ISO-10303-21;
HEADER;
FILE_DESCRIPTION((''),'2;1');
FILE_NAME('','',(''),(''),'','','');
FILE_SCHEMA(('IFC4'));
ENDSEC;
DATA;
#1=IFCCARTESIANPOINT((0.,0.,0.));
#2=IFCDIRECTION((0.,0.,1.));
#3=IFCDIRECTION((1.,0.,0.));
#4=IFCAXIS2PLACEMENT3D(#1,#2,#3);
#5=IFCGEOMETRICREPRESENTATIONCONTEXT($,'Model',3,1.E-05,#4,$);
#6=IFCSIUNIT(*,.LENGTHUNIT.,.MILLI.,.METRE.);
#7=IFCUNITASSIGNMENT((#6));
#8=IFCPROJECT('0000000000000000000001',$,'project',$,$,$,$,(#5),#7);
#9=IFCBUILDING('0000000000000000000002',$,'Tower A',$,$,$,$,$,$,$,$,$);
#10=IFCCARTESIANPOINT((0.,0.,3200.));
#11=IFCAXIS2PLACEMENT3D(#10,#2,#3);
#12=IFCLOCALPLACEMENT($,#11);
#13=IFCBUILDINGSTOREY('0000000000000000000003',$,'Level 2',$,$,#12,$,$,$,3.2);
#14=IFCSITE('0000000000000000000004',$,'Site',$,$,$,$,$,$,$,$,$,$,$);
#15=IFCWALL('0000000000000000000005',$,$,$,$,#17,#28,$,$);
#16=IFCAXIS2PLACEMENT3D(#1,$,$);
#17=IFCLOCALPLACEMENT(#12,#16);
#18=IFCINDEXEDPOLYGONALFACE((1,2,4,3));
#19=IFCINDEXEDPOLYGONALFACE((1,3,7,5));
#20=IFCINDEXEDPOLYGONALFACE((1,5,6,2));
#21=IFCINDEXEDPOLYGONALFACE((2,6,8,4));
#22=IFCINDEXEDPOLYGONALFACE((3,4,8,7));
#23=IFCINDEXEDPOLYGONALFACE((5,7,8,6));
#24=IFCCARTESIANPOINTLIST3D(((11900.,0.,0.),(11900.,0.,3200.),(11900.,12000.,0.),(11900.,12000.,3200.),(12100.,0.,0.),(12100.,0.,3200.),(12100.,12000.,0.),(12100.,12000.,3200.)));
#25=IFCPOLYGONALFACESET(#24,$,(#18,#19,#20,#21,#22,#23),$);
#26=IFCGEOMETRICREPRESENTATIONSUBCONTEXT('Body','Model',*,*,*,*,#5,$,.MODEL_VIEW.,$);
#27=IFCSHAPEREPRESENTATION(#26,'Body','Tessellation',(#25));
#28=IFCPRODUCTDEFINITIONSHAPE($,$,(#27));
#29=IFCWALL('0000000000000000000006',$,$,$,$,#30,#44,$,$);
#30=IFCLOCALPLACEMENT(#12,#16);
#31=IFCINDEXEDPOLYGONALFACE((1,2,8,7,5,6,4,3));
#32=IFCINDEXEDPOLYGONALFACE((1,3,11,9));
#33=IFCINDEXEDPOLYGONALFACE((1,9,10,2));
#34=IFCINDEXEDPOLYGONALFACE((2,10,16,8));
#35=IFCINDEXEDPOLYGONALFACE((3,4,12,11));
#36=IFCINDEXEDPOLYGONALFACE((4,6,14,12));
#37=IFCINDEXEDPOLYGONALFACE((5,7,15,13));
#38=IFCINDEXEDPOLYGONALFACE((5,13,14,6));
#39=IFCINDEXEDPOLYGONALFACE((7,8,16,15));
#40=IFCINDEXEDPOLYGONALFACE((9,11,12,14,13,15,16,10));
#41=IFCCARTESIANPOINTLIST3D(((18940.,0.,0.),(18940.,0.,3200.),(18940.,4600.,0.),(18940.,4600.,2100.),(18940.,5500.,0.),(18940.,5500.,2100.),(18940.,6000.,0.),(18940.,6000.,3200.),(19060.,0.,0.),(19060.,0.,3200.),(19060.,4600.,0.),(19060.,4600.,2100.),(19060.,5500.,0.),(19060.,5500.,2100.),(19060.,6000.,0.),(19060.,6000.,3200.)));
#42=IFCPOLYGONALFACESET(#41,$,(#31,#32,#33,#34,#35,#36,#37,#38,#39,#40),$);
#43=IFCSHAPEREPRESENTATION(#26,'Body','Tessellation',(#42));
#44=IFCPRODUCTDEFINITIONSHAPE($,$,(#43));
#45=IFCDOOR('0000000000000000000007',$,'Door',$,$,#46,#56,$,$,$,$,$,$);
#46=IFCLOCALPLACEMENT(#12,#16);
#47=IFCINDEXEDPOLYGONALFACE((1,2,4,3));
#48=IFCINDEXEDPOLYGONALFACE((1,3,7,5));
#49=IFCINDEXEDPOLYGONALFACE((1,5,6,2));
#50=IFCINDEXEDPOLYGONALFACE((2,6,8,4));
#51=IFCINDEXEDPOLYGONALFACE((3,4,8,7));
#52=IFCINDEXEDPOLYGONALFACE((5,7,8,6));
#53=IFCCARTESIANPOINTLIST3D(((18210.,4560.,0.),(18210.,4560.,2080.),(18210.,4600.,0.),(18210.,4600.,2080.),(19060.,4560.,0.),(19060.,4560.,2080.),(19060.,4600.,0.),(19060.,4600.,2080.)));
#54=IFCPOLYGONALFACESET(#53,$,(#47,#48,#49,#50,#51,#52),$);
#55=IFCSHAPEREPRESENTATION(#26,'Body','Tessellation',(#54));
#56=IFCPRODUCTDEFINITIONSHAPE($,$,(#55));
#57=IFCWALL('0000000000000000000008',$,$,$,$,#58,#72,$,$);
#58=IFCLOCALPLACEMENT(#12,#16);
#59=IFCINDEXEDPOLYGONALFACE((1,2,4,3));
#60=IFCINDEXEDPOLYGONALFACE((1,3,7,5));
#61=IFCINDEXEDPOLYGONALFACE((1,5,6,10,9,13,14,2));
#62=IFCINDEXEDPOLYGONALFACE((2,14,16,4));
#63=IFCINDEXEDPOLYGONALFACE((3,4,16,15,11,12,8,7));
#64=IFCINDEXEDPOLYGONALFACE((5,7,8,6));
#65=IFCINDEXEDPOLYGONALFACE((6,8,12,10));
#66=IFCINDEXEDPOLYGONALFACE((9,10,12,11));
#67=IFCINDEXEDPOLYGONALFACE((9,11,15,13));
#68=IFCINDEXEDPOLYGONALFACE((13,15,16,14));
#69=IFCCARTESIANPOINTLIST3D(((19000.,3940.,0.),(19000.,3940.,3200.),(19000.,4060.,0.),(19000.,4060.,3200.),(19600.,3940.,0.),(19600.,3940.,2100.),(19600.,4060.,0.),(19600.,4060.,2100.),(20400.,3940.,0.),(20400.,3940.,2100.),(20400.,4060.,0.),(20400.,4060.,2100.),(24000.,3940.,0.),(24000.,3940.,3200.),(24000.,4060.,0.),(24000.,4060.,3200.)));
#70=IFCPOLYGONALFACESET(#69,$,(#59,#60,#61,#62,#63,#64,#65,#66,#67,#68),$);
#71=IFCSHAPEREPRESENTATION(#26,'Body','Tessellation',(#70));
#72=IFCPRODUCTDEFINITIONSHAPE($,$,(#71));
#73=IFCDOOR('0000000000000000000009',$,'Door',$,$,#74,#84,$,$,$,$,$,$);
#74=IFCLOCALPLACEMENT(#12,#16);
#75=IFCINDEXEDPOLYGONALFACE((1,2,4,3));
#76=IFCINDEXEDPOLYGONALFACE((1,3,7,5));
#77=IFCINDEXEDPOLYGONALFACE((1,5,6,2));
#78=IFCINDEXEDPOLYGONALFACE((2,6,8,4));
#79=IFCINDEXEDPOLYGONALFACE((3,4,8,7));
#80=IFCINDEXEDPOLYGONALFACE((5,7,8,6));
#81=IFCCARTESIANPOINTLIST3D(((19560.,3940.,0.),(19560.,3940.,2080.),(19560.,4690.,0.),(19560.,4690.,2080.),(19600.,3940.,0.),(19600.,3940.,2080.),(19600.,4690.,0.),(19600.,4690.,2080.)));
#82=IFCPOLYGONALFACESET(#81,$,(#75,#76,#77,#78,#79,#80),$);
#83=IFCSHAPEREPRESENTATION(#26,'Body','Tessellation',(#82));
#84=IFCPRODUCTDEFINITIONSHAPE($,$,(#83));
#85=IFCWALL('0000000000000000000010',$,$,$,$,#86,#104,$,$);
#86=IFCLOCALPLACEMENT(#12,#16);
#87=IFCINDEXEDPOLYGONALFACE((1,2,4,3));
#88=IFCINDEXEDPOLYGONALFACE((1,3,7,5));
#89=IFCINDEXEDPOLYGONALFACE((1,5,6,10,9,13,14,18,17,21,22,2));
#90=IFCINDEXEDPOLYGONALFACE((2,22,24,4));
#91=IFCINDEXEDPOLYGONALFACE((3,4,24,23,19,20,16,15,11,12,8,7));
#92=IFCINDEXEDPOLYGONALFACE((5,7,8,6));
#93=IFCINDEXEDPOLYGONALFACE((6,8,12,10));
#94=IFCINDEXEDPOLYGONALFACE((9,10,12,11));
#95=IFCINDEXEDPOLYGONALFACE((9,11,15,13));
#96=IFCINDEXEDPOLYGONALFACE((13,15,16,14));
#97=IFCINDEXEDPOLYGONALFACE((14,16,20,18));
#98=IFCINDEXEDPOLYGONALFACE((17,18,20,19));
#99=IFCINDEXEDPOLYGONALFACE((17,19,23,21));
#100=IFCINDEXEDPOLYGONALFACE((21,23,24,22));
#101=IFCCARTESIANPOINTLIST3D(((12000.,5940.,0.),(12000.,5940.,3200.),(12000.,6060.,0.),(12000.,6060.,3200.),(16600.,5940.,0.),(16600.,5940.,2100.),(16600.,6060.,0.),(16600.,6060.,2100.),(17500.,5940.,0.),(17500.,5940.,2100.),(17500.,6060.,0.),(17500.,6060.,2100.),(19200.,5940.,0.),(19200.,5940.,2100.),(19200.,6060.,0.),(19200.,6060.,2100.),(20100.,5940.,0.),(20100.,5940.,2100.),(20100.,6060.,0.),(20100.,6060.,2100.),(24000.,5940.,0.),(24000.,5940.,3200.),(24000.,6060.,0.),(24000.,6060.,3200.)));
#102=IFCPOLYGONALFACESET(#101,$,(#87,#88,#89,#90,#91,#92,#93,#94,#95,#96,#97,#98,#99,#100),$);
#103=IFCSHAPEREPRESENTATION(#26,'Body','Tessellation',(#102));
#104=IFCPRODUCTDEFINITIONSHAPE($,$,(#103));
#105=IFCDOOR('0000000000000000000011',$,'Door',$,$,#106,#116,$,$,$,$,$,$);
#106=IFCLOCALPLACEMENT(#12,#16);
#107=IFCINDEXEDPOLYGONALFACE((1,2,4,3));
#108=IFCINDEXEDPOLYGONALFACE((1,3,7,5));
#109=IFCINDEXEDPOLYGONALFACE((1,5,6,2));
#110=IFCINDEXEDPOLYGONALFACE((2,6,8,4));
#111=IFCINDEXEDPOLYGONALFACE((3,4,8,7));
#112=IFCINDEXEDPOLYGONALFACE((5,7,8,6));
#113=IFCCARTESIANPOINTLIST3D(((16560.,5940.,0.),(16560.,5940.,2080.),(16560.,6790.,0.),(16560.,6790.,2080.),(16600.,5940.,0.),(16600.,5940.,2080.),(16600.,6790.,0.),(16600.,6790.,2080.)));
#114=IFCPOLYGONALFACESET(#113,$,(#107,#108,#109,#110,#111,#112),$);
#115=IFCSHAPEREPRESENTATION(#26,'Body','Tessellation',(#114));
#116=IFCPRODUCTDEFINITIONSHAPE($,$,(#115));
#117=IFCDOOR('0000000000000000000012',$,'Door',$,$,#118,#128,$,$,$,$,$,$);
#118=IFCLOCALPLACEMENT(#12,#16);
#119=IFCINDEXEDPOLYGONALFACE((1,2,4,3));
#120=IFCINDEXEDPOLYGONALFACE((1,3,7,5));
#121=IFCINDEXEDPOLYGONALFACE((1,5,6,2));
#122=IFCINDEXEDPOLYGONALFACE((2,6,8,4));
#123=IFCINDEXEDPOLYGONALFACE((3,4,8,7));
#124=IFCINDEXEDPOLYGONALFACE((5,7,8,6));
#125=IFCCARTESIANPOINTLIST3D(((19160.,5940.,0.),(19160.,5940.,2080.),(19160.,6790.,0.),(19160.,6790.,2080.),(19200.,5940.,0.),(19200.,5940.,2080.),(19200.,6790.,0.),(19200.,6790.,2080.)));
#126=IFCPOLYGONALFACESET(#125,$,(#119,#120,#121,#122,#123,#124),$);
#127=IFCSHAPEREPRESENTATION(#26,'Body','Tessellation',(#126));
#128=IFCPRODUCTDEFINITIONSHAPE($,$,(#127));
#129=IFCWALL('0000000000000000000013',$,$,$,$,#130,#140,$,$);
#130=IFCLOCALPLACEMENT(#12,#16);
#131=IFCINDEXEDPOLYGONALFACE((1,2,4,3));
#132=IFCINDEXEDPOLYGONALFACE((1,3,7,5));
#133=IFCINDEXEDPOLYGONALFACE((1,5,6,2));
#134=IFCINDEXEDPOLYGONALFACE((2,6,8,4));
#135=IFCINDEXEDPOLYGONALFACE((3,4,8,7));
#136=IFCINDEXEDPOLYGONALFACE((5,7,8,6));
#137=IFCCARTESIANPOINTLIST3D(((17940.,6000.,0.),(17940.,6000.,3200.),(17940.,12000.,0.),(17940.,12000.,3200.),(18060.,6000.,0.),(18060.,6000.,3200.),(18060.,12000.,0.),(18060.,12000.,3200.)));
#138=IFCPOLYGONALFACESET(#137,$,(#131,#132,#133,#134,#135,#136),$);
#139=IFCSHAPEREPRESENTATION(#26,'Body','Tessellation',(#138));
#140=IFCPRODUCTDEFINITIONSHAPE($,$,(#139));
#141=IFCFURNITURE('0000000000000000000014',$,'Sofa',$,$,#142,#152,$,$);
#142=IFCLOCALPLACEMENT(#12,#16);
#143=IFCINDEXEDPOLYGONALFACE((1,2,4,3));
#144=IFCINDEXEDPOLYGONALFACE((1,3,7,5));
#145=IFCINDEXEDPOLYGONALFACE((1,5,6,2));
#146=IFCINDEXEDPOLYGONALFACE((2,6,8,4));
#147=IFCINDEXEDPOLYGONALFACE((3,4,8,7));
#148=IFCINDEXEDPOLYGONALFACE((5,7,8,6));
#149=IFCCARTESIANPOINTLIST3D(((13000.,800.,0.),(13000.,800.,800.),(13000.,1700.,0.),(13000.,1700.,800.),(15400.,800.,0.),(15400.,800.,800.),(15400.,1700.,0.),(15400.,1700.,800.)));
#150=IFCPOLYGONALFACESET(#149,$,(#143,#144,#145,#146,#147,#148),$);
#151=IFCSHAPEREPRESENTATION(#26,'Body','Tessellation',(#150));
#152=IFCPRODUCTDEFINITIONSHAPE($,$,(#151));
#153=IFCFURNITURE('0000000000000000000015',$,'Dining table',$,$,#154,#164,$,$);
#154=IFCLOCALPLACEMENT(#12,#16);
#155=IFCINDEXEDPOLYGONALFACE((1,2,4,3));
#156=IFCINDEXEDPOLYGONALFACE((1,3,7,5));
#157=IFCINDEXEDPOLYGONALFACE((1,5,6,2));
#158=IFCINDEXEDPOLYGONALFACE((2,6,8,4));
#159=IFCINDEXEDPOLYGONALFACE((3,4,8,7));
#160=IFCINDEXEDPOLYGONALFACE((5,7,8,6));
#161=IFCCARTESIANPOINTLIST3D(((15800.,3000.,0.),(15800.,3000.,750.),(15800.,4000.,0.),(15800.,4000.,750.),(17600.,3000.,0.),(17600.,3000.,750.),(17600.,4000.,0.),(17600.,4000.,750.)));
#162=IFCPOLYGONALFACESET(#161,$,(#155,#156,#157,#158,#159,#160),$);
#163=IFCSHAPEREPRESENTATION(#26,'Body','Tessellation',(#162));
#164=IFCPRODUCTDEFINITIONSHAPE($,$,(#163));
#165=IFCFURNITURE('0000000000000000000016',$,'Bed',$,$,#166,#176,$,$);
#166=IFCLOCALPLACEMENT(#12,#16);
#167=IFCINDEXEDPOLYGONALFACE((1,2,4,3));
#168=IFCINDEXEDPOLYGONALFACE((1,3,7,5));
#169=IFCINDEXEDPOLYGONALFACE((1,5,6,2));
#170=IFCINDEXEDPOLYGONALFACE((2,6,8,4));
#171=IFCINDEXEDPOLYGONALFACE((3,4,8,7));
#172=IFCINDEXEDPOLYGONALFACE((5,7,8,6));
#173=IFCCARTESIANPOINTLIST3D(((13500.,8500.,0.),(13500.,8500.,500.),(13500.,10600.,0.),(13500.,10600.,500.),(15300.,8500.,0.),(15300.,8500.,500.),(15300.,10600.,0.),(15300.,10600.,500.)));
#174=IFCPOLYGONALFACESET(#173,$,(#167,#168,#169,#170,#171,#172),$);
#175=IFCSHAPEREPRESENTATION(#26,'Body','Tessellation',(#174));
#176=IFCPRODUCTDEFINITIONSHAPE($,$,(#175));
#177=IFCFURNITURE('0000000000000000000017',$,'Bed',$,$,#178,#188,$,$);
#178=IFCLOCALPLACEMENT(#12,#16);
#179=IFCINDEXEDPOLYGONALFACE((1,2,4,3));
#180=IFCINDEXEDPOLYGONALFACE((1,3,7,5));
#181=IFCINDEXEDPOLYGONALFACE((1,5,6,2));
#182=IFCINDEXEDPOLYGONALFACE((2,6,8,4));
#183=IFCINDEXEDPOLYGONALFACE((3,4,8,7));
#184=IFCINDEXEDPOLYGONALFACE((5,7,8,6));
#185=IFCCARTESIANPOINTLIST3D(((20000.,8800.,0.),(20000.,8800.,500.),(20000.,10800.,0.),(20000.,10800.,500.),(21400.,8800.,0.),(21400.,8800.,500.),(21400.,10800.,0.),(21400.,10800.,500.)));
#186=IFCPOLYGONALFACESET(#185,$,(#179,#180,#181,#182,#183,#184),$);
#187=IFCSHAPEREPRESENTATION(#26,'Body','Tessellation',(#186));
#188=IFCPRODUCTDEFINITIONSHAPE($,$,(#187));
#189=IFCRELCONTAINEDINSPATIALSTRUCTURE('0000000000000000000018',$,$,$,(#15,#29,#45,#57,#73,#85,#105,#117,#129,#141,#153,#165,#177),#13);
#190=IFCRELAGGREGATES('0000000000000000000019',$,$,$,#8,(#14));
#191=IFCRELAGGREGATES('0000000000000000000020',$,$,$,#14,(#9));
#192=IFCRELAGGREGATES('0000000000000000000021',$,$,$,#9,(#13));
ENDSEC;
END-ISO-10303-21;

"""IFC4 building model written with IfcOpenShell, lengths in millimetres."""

from ifc_helpers import new_model, si_unit, frame, origin_with_axes, place, context, subcontext, project, spatial, indexed_curve, outline, extrude, element, fill, save


model = new_model("IFC4")

# Units and contexts
model_context = context("Model", 3, precision=1e-05, world=origin_with_axes())
body_context = subcontext(model_context, "Body", "Model", "MODEL_VIEW")
ifc_project = project(units=[si_unit("LENGTHUNIT", "METRE", prefix="MILLI")], contexts=[model_context])

# Site, building, storey
site = spatial("IfcSite", under=ifc_project, Name="Site")
building = spatial("IfcBuilding", under=site, Name="Tower A")
storey_placement = place(None, frame((0.0, 0.0, 3200.0), z_axis=(0.0, 0.0, 1.0), x_axis=(1.0, 0.0, 0.0)))
storey = spatial("IfcBuildingStorey", under=building, at=storey_placement, Name="Level 2", Elevation=3.2)

# Wall
wall_1_placement = place(storey_placement, frame((12100.0, 0.0, 0.0), z_axis=(0.0, 0.0, 1.0), x_axis=(0.0, 1.0, 0.0)))
element("IfcWall", 1, at=wall_1_placement, inside=storey, context=body_context, shape_type="SweptSolid", body=[
    extrude(outline(indexed_curve([(0.0, 0.0), (0.0, 200.0), (12000.0, 200.0), (12000.0, 0.0), (0.0, 0.0)], self_intersect=False)), origin_with_axes(), (0.0, 0.0, 1.0), 3200.0),
])

# Walls, openings, doors
wall_2_placement = place(storey_placement, frame((19060.0, 0.0, 0.0), z_axis=(0.0, 0.0, 1.0), x_axis=(0.0, 1.0, 0.0)))
wall_2 = element("IfcWall", 2, at=wall_2_placement, inside=storey, context=body_context, shape_type="SweptSolid", body=[
    extrude(outline(indexed_curve([(0.0, 0.0), (0.0, 120.0), (6000.0, 120.0), (6000.0, 0.0), (0.0, 0.0)], self_intersect=False)), origin_with_axes(), (0.0, 0.0, 1.0), 3200.0),
])
opening_1_placement = place(wall_2_placement, frame((4600.0, 0.0, 0.0), z_axis=(0.0, 0.0, 1.0), x_axis=(1.0, 0.0, 0.0)))
opening_1 = element("IfcOpeningElement", 3, at=opening_1_placement, cuts=wall_2, context=body_context, shape_type="SweptSolid", body=[
    extrude(outline(indexed_curve([(0.0, 0.0), (0.0, 120.0), (900.0, 120.0), (900.0, 0.0), (0.0, 0.0)], self_intersect=False)), origin_with_axes(), (0.0, 0.0, 1.0), 2100.0),
])
door_1_placement = place(storey_placement, frame((19060.0, 4600.0, 0.0), z_axis=(0.0, 0.0, 1.0), x_axis=(-1.0, 0.0, 0.0)))
door_1 = element("IfcDoor", 4, at=door_1_placement, inside=storey, Name="Door", context=body_context, shape_type="SweptSolid", body=[
    extrude(outline(indexed_curve([(0.0, 0.0), (0.0, 40.0), (850.0, 40.0), (850.0, 0.0), (0.0, 0.0)], self_intersect=False)), origin_with_axes(), (0.0, 0.0, 1.0), 2080.0),
])
fill(opening_1, door_1)
wall_3_placement = place(storey_placement, frame((19000.0, 3940.0, 0.0), z_axis=(0.0, 0.0, 1.0), x_axis=(1.0, 0.0, 0.0)))
wall_3 = element("IfcWall", 5, at=wall_3_placement, inside=storey, context=body_context, shape_type="SweptSolid", body=[
    extrude(outline(indexed_curve([(0.0, 0.0), (0.0, 120.0), (5000.0, 120.0), (5000.0, 0.0), (0.0, 0.0)], self_intersect=False)), origin_with_axes(), (0.0, 0.0, 1.0), 3200.0),
])
opening_2_placement = place(wall_3_placement, frame((600.0, 0.0, 0.0), z_axis=(0.0, 0.0, 1.0), x_axis=(1.0, 0.0, 0.0)))
opening_2 = element("IfcOpeningElement", 6, at=opening_2_placement, cuts=wall_3, context=body_context, shape_type="SweptSolid", body=[
    extrude(outline(indexed_curve([(0.0, 0.0), (0.0, 120.0), (800.0, 120.0), (800.0, 0.0), (0.0, 0.0)], self_intersect=False)), origin_with_axes(), (0.0, 0.0, 1.0), 2100.0),
])
door_2_placement = place(storey_placement, frame((19600.0, 3940.0, 0.0), z_axis=(0.0, 0.0, 1.0), x_axis=(0.0, 1.0, 0.0)))
door_2 = element("IfcDoor", 7, at=door_2_placement, inside=storey, Name="Door", context=body_context, shape_type="SweptSolid", body=[
    extrude(outline(indexed_curve([(0.0, 0.0), (0.0, 40.0), (750.0, 40.0), (750.0, 0.0), (0.0, 0.0)], self_intersect=False)), origin_with_axes(), (0.0, 0.0, 1.0), 2080.0),
])
fill(opening_2, door_2)

# Wall, openings, doors
wall_4_placement = place(storey_placement, frame((12000.0, 5940.0, 0.0), z_axis=(0.0, 0.0, 1.0), x_axis=(1.0, 0.0, 0.0)))
wall_4 = element("IfcWall", 8, at=wall_4_placement, inside=storey, context=body_context, shape_type="SweptSolid", body=[
    extrude(outline(indexed_curve([(0.0, 0.0), (0.0, 120.0), (12000.0, 120.0), (12000.0, 0.0), (0.0, 0.0)], self_intersect=False)), origin_with_axes(), (0.0, 0.0, 1.0), 3200.0),
])
opening_3_placement = place(wall_4_placement, frame((4600.0, 0.0, 0.0), z_axis=(0.0, 0.0, 1.0), x_axis=(1.0, 0.0, 0.0)))
opening_3 = element("IfcOpeningElement", 9, at=opening_3_placement, cuts=wall_4, context=body_context, shape_type="SweptSolid", body=[
    extrude(outline(indexed_curve([(0.0, 0.0), (0.0, 120.0), (900.0, 120.0), (900.0, 0.0), (0.0, 0.0)], self_intersect=False)), origin_with_axes(), (0.0, 0.0, 1.0), 2100.0),
])
opening_4_placement = place(wall_4_placement, frame((7200.0, 0.0, 0.0), z_axis=(0.0, 0.0, 1.0), x_axis=(1.0, 0.0, 0.0)))
opening_4 = element("IfcOpeningElement", 10, at=opening_4_placement, cuts=wall_4, context=body_context, shape_type="SweptSolid", body=[
    extrude(outline(indexed_curve([(0.0, 0.0), (0.0, 120.0), (900.0, 120.0), (900.0, 0.0), (0.0, 0.0)], self_intersect=False)), origin_with_axes(), (0.0, 0.0, 1.0), 2100.0),
])
door_3_placement = place(storey_placement, frame((16600.0, 5940.0, 0.0), z_axis=(0.0, 0.0, 1.0), x_axis=(0.0, 1.0, 0.0)))
door_3 = element("IfcDoor", 11, at=door_3_placement, inside=storey, Name="Door", context=body_context, shape_type="SweptSolid", body=[
    extrude(outline(indexed_curve([(0.0, 0.0), (0.0, 40.0), (850.0, 40.0), (850.0, 0.0), (0.0, 0.0)], self_intersect=False)), origin_with_axes(), (0.0, 0.0, 1.0), 2080.0),
])
fill(opening_3, door_3)
door_4_placement = place(storey_placement, frame((19200.0, 5940.0, 0.0), z_axis=(0.0, 0.0, 1.0), x_axis=(0.0, 1.0, 0.0)))
door_4 = element("IfcDoor", 12, at=door_4_placement, inside=storey, Name="Door", context=body_context, shape_type="SweptSolid", body=[
    extrude(outline(indexed_curve([(0.0, 0.0), (0.0, 40.0), (850.0, 40.0), (850.0, 0.0), (0.0, 0.0)], self_intersect=False)), origin_with_axes(), (0.0, 0.0, 1.0), 2080.0),
])
fill(opening_4, door_4)

# Wall
wall_5_placement = place(storey_placement, frame((18060.0, 6000.0, 0.0), z_axis=(0.0, 0.0, 1.0), x_axis=(0.0, 1.0, 0.0)))
element("IfcWall", 13, at=wall_5_placement, inside=storey, context=body_context, shape_type="SweptSolid", body=[
    extrude(outline(indexed_curve([(0.0, 0.0), (0.0, 120.0), (6000.0, 120.0), (6000.0, 0.0), (0.0, 0.0)], self_intersect=False)), origin_with_axes(), (0.0, 0.0, 1.0), 3200.0),
])

# Furniture
furniture_1_placement = place(storey_placement, frame((13000.0, 800.0, 0.0), z_axis=(0.0, 0.0, 1.0), x_axis=(1.0, 0.0, 0.0)))
element("IfcFurniture", 14, at=furniture_1_placement, inside=storey, Name="Sofa", context=body_context, shape_type="SweptSolid", body=[
    extrude(outline(indexed_curve([(0.0, 0.0), (2400.0, 0.0), (2400.0, 900.0), (0.0, 900.0)])), None, (0.0, 0.0, 1.0), 800.0),
])
furniture_2_placement = place(storey_placement, frame((15800.0, 3000.0, 0.0), z_axis=(0.0, 0.0, 1.0), x_axis=(1.0, 0.0, 0.0)))
element("IfcFurniture", 15, at=furniture_2_placement, inside=storey, Name="Dining table", context=body_context, shape_type="SweptSolid", body=[
    extrude(outline(indexed_curve([(0.0, 0.0), (1800.0, 0.0), (1800.0, 1000.0), (0.0, 1000.0)])), None, (0.0, 0.0, 1.0), 750.0),
])
furniture_3_placement = place(storey_placement, frame((13500.0, 8500.0, 0.0), z_axis=(0.0, 0.0, 1.0), x_axis=(1.0, 0.0, 0.0)))
element("IfcFurniture", 16, at=furniture_3_placement, inside=storey, Name="Bed", context=body_context, shape_type="SweptSolid", body=[
    extrude(outline(indexed_curve([(0.0, 0.0), (1800.0, 0.0), (1800.0, 2100.0), (0.0, 2100.0)])), None, (0.0, 0.0, 1.0), 500.0),
])
furniture_4_placement = place(storey_placement, frame((20000.0, 8800.0, 0.0), z_axis=(0.0, 0.0, 1.0), x_axis=(1.0, 0.0, 0.0)))
element("IfcFurniture", 17, at=furniture_4_placement, inside=storey, Name="Bed", context=body_context, shape_type="SweptSolid", body=[
    extrude(outline(indexed_curve([(0.0, 0.0), (1400.0, 0.0), (1400.0, 2000.0), (0.0, 2000.0)])), None, (0.0, 0.0, 1.0), 500.0),
])

save(model, "model.ifc")
